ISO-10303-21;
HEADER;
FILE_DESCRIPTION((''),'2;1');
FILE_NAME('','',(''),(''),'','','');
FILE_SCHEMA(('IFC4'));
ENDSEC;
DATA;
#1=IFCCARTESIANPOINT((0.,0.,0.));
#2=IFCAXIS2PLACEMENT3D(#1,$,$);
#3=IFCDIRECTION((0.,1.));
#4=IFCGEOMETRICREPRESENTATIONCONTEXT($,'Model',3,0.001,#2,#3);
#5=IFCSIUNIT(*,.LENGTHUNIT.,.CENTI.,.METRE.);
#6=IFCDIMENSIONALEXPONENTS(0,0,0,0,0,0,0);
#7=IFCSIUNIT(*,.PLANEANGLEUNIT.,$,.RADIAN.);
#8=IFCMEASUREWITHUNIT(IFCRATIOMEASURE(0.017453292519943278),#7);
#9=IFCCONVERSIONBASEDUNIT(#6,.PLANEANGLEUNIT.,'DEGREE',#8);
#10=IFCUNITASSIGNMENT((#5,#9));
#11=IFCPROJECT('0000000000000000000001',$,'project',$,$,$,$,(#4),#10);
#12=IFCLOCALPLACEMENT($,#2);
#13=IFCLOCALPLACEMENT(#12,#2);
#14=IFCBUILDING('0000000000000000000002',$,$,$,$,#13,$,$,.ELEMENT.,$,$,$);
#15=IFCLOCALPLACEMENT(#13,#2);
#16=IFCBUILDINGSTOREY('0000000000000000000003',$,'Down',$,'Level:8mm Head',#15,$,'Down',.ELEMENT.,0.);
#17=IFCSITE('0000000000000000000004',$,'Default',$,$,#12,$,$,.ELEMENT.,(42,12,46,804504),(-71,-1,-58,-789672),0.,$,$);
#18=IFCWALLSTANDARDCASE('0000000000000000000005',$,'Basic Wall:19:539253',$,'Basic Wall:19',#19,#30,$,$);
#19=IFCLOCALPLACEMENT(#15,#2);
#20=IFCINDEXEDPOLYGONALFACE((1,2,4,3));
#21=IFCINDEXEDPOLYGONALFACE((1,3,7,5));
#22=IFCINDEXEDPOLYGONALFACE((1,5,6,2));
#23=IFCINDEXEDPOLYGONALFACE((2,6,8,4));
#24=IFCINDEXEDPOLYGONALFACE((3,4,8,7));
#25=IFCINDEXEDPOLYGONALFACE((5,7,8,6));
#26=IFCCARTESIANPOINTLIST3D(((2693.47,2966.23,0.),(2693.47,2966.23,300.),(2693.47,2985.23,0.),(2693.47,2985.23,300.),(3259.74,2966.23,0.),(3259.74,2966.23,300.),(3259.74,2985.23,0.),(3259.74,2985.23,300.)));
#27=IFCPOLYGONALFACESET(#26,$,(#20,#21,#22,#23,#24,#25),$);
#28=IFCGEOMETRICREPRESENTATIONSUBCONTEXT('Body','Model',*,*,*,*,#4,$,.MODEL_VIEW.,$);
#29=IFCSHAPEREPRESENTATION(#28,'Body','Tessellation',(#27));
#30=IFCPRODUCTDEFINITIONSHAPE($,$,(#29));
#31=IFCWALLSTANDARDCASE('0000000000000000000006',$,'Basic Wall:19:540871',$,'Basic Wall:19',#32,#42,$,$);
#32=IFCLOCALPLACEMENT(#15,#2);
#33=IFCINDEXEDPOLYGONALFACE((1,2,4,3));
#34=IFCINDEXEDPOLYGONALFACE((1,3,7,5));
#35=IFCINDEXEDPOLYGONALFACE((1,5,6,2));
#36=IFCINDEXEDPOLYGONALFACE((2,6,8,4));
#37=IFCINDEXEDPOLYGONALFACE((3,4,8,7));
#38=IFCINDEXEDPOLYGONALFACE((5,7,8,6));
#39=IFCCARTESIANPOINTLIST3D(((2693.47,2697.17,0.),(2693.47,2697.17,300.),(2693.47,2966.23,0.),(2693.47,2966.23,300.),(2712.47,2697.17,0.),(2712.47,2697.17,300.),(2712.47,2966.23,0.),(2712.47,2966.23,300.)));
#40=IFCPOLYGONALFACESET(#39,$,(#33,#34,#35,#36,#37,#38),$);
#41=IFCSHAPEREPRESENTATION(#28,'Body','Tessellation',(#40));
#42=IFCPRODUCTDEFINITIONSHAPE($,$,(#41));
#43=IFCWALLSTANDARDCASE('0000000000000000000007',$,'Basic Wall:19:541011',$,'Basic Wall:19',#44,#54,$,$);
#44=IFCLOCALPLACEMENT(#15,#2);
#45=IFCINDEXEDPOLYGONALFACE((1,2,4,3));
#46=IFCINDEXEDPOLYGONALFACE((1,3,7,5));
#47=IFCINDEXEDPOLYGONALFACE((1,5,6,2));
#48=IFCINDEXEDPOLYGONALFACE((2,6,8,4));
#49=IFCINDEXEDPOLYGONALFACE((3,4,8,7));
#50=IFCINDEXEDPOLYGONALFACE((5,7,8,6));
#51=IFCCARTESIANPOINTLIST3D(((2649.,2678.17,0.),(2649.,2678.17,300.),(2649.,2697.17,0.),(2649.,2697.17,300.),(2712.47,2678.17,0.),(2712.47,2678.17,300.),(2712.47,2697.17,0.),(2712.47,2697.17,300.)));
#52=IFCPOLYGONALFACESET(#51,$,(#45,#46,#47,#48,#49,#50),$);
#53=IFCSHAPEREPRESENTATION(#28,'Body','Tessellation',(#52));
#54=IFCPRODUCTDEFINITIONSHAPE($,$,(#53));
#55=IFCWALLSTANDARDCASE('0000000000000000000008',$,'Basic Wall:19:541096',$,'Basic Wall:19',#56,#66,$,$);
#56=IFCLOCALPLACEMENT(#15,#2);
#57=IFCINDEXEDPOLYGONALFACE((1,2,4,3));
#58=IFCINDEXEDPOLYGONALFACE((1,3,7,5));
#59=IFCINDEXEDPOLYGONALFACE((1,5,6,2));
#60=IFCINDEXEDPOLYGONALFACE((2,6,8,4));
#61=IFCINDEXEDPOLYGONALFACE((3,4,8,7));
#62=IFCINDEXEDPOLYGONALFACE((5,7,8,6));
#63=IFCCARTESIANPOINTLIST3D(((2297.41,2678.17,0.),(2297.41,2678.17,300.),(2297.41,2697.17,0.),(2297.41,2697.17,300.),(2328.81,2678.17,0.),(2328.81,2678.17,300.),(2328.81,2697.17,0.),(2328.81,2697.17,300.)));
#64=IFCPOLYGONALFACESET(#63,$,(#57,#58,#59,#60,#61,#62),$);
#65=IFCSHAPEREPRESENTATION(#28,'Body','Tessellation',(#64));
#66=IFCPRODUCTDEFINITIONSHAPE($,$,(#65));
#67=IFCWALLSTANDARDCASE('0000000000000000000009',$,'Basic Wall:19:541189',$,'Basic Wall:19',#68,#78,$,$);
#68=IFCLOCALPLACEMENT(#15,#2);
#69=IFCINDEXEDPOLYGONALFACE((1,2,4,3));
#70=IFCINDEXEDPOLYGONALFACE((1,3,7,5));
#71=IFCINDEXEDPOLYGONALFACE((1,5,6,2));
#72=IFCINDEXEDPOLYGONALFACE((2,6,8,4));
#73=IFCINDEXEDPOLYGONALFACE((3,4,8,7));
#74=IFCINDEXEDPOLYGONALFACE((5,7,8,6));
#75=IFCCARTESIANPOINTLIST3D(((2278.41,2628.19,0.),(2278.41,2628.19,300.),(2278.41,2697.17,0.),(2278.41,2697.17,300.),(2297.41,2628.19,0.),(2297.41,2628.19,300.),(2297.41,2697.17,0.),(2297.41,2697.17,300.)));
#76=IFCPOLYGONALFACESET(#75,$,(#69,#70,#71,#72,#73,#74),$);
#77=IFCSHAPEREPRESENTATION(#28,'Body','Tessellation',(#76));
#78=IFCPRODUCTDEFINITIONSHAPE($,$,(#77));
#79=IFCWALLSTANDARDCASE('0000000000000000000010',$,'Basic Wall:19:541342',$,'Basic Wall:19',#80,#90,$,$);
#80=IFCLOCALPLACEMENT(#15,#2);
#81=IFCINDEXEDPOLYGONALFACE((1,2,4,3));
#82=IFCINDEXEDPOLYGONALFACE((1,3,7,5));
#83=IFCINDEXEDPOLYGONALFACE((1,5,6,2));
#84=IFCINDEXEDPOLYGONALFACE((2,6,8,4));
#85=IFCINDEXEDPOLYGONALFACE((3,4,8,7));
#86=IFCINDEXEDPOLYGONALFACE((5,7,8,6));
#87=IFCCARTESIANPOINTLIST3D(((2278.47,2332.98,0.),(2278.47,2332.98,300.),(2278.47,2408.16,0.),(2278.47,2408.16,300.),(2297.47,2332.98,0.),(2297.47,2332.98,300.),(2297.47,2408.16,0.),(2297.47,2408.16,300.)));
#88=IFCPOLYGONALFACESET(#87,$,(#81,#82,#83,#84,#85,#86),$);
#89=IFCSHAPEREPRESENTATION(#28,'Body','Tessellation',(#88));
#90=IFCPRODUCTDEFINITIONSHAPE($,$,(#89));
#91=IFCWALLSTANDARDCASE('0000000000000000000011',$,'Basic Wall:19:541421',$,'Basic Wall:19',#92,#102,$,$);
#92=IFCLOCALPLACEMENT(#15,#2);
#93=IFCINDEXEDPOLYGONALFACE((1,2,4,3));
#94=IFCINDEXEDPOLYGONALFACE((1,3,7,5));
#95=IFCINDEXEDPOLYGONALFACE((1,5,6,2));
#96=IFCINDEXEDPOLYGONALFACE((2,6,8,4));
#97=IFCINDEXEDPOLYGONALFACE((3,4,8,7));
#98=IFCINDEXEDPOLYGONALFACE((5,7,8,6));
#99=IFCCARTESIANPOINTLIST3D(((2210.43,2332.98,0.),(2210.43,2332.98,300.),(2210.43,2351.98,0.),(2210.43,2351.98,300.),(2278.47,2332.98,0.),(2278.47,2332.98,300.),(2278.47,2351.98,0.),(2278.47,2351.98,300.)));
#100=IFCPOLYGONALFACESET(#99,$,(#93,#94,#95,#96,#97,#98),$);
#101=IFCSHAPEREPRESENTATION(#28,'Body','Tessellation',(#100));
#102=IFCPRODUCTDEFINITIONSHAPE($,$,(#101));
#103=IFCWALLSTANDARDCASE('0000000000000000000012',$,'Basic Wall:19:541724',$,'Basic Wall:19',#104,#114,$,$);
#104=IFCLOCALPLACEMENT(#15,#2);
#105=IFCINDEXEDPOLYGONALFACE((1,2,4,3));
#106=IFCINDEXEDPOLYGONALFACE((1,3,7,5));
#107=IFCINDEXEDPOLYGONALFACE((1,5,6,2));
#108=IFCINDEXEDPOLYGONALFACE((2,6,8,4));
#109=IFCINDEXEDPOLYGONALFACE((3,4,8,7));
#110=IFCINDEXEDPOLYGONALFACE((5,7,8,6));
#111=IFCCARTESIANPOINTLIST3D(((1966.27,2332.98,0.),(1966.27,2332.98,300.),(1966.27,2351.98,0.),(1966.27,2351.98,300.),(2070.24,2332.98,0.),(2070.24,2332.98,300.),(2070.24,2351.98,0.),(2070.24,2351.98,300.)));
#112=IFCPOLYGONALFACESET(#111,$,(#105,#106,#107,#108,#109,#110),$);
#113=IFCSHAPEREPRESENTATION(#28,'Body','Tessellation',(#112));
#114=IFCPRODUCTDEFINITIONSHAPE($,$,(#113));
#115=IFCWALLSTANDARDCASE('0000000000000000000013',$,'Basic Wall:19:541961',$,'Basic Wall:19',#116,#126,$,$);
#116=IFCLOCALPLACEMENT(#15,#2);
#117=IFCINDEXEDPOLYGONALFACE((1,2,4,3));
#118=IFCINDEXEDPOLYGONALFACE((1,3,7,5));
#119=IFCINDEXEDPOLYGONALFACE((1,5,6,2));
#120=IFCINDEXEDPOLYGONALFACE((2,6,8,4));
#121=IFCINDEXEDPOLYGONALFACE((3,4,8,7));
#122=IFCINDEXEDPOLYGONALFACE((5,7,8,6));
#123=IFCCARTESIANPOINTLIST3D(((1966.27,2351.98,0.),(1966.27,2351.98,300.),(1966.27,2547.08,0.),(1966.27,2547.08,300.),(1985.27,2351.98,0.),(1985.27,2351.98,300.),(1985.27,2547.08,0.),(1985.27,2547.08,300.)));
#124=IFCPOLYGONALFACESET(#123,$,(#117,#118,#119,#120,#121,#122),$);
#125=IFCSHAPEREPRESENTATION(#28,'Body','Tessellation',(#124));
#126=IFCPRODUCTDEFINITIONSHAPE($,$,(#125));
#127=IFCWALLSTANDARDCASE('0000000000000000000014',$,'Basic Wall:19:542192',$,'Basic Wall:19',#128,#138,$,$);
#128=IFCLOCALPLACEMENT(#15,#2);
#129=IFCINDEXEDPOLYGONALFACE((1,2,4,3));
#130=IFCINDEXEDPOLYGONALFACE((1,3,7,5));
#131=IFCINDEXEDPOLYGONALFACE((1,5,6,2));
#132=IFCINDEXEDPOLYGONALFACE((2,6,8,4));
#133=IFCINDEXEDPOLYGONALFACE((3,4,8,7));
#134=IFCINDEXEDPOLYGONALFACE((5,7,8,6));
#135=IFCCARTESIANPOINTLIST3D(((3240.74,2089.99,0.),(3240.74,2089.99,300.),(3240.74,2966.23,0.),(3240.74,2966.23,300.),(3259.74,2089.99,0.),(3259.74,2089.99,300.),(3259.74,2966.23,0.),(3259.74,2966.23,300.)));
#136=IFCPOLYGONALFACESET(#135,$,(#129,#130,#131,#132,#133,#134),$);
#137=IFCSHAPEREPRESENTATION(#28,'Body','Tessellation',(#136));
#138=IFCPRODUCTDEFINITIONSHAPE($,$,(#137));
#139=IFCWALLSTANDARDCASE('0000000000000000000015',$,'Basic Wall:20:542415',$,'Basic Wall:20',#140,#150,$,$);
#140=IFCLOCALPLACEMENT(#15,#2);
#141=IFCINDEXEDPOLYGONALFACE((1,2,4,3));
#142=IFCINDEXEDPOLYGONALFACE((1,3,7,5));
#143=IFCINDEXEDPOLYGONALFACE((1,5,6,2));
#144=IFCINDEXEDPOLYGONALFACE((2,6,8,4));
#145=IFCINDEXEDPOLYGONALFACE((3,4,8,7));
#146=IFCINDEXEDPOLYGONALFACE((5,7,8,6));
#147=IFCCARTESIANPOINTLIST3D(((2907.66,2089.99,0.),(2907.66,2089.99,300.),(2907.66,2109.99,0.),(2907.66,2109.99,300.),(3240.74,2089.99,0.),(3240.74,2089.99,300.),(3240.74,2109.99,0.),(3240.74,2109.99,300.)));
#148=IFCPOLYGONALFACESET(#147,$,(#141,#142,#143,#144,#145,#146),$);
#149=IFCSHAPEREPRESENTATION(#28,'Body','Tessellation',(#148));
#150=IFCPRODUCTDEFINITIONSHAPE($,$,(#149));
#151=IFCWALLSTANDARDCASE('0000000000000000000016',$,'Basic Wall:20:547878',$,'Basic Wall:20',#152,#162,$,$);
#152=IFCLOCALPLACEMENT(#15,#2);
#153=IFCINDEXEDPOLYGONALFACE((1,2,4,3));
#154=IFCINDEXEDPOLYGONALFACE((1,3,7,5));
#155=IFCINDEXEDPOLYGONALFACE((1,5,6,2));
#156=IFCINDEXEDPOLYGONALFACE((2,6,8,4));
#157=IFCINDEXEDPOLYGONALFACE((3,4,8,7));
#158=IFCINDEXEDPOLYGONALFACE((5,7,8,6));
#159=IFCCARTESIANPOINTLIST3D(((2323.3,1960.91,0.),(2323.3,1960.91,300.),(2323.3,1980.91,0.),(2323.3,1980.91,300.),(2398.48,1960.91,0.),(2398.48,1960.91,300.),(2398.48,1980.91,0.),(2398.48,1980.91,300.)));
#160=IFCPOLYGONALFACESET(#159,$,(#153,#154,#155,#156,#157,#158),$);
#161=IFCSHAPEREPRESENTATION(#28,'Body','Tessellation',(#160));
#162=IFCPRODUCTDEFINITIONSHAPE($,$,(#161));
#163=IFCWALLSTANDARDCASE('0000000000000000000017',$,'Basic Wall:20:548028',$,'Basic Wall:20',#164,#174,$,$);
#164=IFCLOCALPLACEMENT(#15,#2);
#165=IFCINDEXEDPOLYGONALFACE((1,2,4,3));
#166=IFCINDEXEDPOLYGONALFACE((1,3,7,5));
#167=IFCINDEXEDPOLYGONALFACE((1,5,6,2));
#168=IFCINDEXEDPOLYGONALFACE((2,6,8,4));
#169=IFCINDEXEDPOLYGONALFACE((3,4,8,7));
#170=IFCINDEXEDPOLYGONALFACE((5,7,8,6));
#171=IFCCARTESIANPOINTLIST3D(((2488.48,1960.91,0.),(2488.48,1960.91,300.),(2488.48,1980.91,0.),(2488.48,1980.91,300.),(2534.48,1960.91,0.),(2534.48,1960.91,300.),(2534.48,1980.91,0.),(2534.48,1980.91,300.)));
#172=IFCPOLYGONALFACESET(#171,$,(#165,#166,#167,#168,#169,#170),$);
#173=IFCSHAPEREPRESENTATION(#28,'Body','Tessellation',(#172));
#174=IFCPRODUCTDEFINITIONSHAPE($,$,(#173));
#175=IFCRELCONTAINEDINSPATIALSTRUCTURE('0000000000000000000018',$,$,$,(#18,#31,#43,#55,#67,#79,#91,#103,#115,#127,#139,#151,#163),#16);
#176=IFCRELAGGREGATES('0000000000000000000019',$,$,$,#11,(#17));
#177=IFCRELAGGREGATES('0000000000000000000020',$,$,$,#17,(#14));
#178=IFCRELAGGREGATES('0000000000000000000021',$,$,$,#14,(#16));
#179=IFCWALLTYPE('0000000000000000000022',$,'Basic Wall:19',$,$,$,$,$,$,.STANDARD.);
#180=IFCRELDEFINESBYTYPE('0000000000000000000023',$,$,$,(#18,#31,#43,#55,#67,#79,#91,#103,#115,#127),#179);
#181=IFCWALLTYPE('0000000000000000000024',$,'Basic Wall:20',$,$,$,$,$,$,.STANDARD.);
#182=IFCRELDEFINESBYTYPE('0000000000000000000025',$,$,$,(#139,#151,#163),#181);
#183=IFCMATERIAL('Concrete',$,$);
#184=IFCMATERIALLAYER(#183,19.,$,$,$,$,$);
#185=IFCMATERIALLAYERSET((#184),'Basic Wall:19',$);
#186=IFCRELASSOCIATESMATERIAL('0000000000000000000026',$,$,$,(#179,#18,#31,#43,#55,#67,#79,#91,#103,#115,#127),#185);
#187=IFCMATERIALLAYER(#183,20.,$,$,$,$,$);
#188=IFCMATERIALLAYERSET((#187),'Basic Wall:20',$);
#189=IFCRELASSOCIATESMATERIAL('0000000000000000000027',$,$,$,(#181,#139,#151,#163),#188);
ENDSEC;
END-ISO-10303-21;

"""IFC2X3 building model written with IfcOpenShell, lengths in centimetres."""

from ifc_helpers import new_model, entity, si_unit, converted_unit, direction, frame, frame_2d, origin, place, context, subcontext, project, spatial, rectangle, extrude, material, layer, layer_set, layer_usage, type_object, element, save


model = new_model("IFC2X3")

# Units and contexts
model_context = context("Model", 3, precision=0.001, world=origin(), true_north=direction((0.0, 1.0)))
body_context = subcontext(model_context, "Body", "Model", "MODEL_VIEW")
ifc_project = project(units=[si_unit("LENGTHUNIT", "METRE", prefix="CENTI"), converted_unit("PLANEANGLEUNIT", "DEGREE", entity("IfcRatioMeasure", 0.017453292519943278), si_unit("PLANEANGLEUNIT", "RADIAN"), dimensions=[0, 0, 0, 0, 0, 0, 0])], contexts=[model_context])

# Site, building, storey
site_placement = place(None, origin())
site = spatial("IfcSite", under=ifc_project, at=site_placement, Name="Default", CompositionType="ELEMENT", RefLatitude=(42, 12, 46, 804504), RefLongitude=(-71, -1, -58, -789672), RefElevation=0.0)
building_placement = place(site_placement, origin())
building = spatial("IfcBuilding", under=site, at=building_placement, CompositionType="ELEMENT")
storey_placement = place(building_placement, origin())
storey = spatial("IfcBuildingStorey", under=building, at=storey_placement, Name="Down", ObjectType="Level:8mm Head", LongName="Down", CompositionType="ELEMENT", Elevation=0.0)

# Walls
ifc_material = material(Name="Concrete")
ifc_layer_1 = layer(ifc_material, 19.0)
ifc_layer_set_1 = layer_set([ifc_layer_1], Name="Basic Wall:19")
ifc_layer_usage_1 = layer_usage(ifc_layer_set_1, "AXIS2", "POSITIVE", -9.5)
wall_type_1 = type_object("IfcWallType", Name="Basic Wall:19", PredefinedType="STANDARD", material=ifc_layer_set_1)
wall_1_placement = place(storey_placement, frame((3259.74, 2975.73, 0.0), z_axis=(0.0, 0.0, 1.0), x_axis=(-1.0, 0.0, 0.0)))
element("IfcWallStandardCase", 1, at=wall_1_placement, inside=storey, type_object=wall_type_1, material=ifc_layer_usage_1, Name="Basic Wall:19:539253", ObjectType="Basic Wall:19", context=body_context, shape_type="SweptSolid", body=[
    extrude(rectangle(XDim=566.27, YDim=19.0, at=frame_2d((283.13, 0.0), x_axis=(-1.0, 0.0))), origin(), (0.0, 0.0, 1.0), 300.0),
])
ifc_layer_usage_2 = layer_usage(ifc_layer_set_1, "AXIS2", "POSITIVE", -9.5)
wall_2_placement = place(storey_placement, frame((2702.97, 2966.23, 0.0), z_axis=(0.0, 0.0, 1.0), x_axis=(0.0, -1.0, 0.0)))
element("IfcWallStandardCase", 2, at=wall_2_placement, inside=storey, type_object=wall_type_1, material=ifc_layer_usage_2, Name="Basic Wall:19:540871", ObjectType="Basic Wall:19", context=body_context, shape_type="SweptSolid", body=[
    extrude(rectangle(XDim=269.06, YDim=19.0, at=frame_2d((134.53, 0.0), x_axis=(-1.0, 0.0))), origin(), (0.0, 0.0, 1.0), 300.0),
])
ifc_layer_usage_3 = layer_usage(ifc_layer_set_1, "AXIS2", "NEGATIVE", 9.5)
wall_3_placement = place(storey_placement, frame((2712.47, 2687.67, 0.0), z_axis=(0.0, 0.0, 1.0), x_axis=(-1.0, 0.0, 0.0)))
element("IfcWallStandardCase", 3, at=wall_3_placement, inside=storey, type_object=wall_type_1, material=ifc_layer_usage_3, Name="Basic Wall:19:541011", ObjectType="Basic Wall:19", context=body_context, shape_type="SweptSolid", body=[
    extrude(rectangle(XDim=63.47, YDim=19.0, at=frame_2d((31.74, 0.0), x_axis=(-1.0, 0.0))), origin(), (0.0, 0.0, 1.0), 300.0),
])
ifc_layer_usage_4 = layer_usage(ifc_layer_set_1, "AXIS2", "NEGATIVE", 9.5)
wall_4_placement = place(storey_placement, frame((2328.81, 2687.67, 0.0), z_axis=(0.0, 0.0, 1.0), x_axis=(-1.0, 0.0, 0.0)))
element("IfcWallStandardCase", 4, at=wall_4_placement, inside=storey, type_object=wall_type_1, material=ifc_layer_usage_4, Name="Basic Wall:19:541096", ObjectType="Basic Wall:19", context=body_context, shape_type="SweptSolid", body=[
    extrude(rectangle(XDim=31.4, YDim=19.0, at=frame_2d((15.7, 0.0), x_axis=(-1.0, 0.0))), origin(), (0.0, 0.0, 1.0), 300.0),
])
ifc_layer_usage_5 = layer_usage(ifc_layer_set_1, "AXIS2", "POSITIVE", -9.5)
wall_5_placement = place(storey_placement, frame((2287.91, 2697.17, 0.0), z_axis=(0.0, 0.0, 1.0), x_axis=(0.0, -1.0, 0.0)))
element("IfcWallStandardCase", 5, at=wall_5_placement, inside=storey, type_object=wall_type_1, material=ifc_layer_usage_5, Name="Basic Wall:19:541189", ObjectType="Basic Wall:19", context=body_context, shape_type="SweptSolid", body=[
    extrude(rectangle(XDim=68.98, YDim=19.0, at=frame_2d((34.49, 0.0), x_axis=(-1.0, 0.0))), origin(), (0.0, 0.0, 1.0), 300.0),
])
ifc_layer_usage_6 = layer_usage(ifc_layer_set_1, "AXIS2", "NEGATIVE", 9.5)
wall_6_placement = place(storey_placement, frame((2287.97, 2408.16, 0.0), z_axis=(0.0, 0.0, 1.0), x_axis=(0.0, -1.0, 0.0)))
element("IfcWallStandardCase", 6, at=wall_6_placement, inside=storey, type_object=wall_type_1, material=ifc_layer_usage_6, Name="Basic Wall:19:541342", ObjectType="Basic Wall:19", context=body_context, shape_type="SweptSolid", body=[
    extrude(rectangle(XDim=75.18, YDim=19.0, at=frame_2d((37.59, 0.0), x_axis=(-1.0, 0.0))), origin(), (0.0, 0.0, 1.0), 300.0),
])
ifc_layer_usage_7 = layer_usage(ifc_layer_set_1, "AXIS2", "NEGATIVE", 9.5)
wall_7_placement = place(storey_placement, frame((2278.47, 2342.48, 0.0), z_axis=(0.0, 0.0, 1.0), x_axis=(-1.0, 0.0, 0.0)))
element("IfcWallStandardCase", 7, at=wall_7_placement, inside=storey, type_object=wall_type_1, material=ifc_layer_usage_7, Name="Basic Wall:19:541421", ObjectType="Basic Wall:19", context=body_context, shape_type="SweptSolid", body=[
    extrude(rectangle(XDim=68.04, YDim=19.0, at=frame_2d((34.02, 0.0), x_axis=(-1.0, 0.0))), origin(), (0.0, 0.0, 1.0), 300.0),
])
ifc_layer_usage_8 = layer_usage(ifc_layer_set_1, "AXIS2", "NEGATIVE", 9.5)
wall_8_placement = place(storey_placement, frame((2070.24, 2342.48, 0.0), z_axis=(0.0, 0.0, 1.0), x_axis=(-1.0, 0.0, 0.0)))
element("IfcWallStandardCase", 8, at=wall_8_placement, inside=storey, type_object=wall_type_1, material=ifc_layer_usage_8, Name="Basic Wall:19:541724", ObjectType="Basic Wall:19", context=body_context, shape_type="SweptSolid", body=[
    extrude(rectangle(XDim=103.98, YDim=19.0, at=frame_2d((51.99, 0.0), x_axis=(-1.0, 0.0))), origin(), (0.0, 0.0, 1.0), 300.0),
])
ifc_layer_usage_9 = layer_usage(ifc_layer_set_1, "AXIS2", "NEGATIVE", 9.5)
wall_9_placement = place(storey_placement, frame((1975.77, 2351.98, 0.0), z_axis=(0.0, 0.0, 1.0), x_axis=(0.0, 1.0, 0.0)))
element("IfcWallStandardCase", 9, at=wall_9_placement, inside=storey, type_object=wall_type_1, material=ifc_layer_usage_9, Name="Basic Wall:19:541961", ObjectType="Basic Wall:19", context=body_context, shape_type="SweptSolid", body=[
    extrude(rectangle(XDim=195.1, YDim=19.0, at=frame_2d((97.55, 0.0), x_axis=(-1.0, 0.0))), origin(), (0.0, 0.0, 1.0), 300.0),
])
ifc_layer_usage_10 = layer_usage(ifc_layer_set_1, "AXIS2", "NEGATIVE", 9.5)
wall_10_placement = place(storey_placement, frame((3250.24, 2966.23, 0.0), z_axis=(0.0, 0.0, 1.0), x_axis=(0.0, -1.0, 0.0)))
element("IfcWallStandardCase", 10, at=wall_10_placement, inside=storey, type_object=wall_type_1, material=ifc_layer_usage_10, Name="Basic Wall:19:542192", ObjectType="Basic Wall:19", context=body_context, shape_type="SweptSolid", body=[
    extrude(rectangle(XDim=876.23, YDim=19.0, at=frame_2d((438.12, 0.0), x_axis=(-1.0, 0.0))), origin(), (0.0, 0.0, 1.0), 300.0),
])
ifc_layer_2 = layer(ifc_material, 20.0)
ifc_layer_set_2 = layer_set([ifc_layer_2], Name="Basic Wall:20")
ifc_layer_usage_11 = layer_usage(ifc_layer_set_2, "AXIS2", "NEGATIVE", 10.0)
wall_type_2 = type_object("IfcWallType", Name="Basic Wall:20", PredefinedType="STANDARD", material=ifc_layer_set_2)
wall_11_placement = place(storey_placement, frame((2907.66, 2099.99, 0.0)))
element("IfcWallStandardCase", 11, at=wall_11_placement, inside=storey, type_object=wall_type_2, material=ifc_layer_usage_11, Name="Basic Wall:20:542415", ObjectType="Basic Wall:20", context=body_context, shape_type="SweptSolid", body=[
    extrude(rectangle(XDim=333.07, YDim=20.0, at=frame_2d((166.54, 0.0), x_axis=(-1.0, 0.0))), origin(), (0.0, 0.0, 1.0), 300.0),
])
ifc_layer_usage_12 = layer_usage(ifc_layer_set_2, "AXIS2", "POSITIVE", -10.0)
wall_12_placement = place(storey_placement, frame((2323.3, 1970.91, 0.0)))
element("IfcWallStandardCase", 12, at=wall_12_placement, inside=storey, type_object=wall_type_2, material=ifc_layer_usage_12, Name="Basic Wall:20:547878", ObjectType="Basic Wall:20", context=body_context, shape_type="SweptSolid", body=[
    extrude(rectangle(XDim=75.18, YDim=20.0, at=frame_2d((37.59, 0.0), x_axis=(-1.0, 0.0))), origin(), (0.0, 0.0, 1.0), 300.0),
])
ifc_layer_usage_13 = layer_usage(ifc_layer_set_2, "AXIS2", "POSITIVE", -10.0)
wall_13_placement = place(storey_placement, frame((2488.48, 1970.91, 0.0)))
element("IfcWallStandardCase", 13, at=wall_13_placement, inside=storey, type_object=wall_type_2, material=ifc_layer_usage_13, Name="Basic Wall:20:548028", ObjectType="Basic Wall:20", context=body_context, shape_type="SweptSolid", body=[
    extrude(rectangle(XDim=46.0, YDim=20.0, at=frame_2d((23.0, 0.0), x_axis=(-1.0, 0.0))), origin(), (0.0, 0.0, 1.0), 300.0),
])

save(model, "model.ifc")
